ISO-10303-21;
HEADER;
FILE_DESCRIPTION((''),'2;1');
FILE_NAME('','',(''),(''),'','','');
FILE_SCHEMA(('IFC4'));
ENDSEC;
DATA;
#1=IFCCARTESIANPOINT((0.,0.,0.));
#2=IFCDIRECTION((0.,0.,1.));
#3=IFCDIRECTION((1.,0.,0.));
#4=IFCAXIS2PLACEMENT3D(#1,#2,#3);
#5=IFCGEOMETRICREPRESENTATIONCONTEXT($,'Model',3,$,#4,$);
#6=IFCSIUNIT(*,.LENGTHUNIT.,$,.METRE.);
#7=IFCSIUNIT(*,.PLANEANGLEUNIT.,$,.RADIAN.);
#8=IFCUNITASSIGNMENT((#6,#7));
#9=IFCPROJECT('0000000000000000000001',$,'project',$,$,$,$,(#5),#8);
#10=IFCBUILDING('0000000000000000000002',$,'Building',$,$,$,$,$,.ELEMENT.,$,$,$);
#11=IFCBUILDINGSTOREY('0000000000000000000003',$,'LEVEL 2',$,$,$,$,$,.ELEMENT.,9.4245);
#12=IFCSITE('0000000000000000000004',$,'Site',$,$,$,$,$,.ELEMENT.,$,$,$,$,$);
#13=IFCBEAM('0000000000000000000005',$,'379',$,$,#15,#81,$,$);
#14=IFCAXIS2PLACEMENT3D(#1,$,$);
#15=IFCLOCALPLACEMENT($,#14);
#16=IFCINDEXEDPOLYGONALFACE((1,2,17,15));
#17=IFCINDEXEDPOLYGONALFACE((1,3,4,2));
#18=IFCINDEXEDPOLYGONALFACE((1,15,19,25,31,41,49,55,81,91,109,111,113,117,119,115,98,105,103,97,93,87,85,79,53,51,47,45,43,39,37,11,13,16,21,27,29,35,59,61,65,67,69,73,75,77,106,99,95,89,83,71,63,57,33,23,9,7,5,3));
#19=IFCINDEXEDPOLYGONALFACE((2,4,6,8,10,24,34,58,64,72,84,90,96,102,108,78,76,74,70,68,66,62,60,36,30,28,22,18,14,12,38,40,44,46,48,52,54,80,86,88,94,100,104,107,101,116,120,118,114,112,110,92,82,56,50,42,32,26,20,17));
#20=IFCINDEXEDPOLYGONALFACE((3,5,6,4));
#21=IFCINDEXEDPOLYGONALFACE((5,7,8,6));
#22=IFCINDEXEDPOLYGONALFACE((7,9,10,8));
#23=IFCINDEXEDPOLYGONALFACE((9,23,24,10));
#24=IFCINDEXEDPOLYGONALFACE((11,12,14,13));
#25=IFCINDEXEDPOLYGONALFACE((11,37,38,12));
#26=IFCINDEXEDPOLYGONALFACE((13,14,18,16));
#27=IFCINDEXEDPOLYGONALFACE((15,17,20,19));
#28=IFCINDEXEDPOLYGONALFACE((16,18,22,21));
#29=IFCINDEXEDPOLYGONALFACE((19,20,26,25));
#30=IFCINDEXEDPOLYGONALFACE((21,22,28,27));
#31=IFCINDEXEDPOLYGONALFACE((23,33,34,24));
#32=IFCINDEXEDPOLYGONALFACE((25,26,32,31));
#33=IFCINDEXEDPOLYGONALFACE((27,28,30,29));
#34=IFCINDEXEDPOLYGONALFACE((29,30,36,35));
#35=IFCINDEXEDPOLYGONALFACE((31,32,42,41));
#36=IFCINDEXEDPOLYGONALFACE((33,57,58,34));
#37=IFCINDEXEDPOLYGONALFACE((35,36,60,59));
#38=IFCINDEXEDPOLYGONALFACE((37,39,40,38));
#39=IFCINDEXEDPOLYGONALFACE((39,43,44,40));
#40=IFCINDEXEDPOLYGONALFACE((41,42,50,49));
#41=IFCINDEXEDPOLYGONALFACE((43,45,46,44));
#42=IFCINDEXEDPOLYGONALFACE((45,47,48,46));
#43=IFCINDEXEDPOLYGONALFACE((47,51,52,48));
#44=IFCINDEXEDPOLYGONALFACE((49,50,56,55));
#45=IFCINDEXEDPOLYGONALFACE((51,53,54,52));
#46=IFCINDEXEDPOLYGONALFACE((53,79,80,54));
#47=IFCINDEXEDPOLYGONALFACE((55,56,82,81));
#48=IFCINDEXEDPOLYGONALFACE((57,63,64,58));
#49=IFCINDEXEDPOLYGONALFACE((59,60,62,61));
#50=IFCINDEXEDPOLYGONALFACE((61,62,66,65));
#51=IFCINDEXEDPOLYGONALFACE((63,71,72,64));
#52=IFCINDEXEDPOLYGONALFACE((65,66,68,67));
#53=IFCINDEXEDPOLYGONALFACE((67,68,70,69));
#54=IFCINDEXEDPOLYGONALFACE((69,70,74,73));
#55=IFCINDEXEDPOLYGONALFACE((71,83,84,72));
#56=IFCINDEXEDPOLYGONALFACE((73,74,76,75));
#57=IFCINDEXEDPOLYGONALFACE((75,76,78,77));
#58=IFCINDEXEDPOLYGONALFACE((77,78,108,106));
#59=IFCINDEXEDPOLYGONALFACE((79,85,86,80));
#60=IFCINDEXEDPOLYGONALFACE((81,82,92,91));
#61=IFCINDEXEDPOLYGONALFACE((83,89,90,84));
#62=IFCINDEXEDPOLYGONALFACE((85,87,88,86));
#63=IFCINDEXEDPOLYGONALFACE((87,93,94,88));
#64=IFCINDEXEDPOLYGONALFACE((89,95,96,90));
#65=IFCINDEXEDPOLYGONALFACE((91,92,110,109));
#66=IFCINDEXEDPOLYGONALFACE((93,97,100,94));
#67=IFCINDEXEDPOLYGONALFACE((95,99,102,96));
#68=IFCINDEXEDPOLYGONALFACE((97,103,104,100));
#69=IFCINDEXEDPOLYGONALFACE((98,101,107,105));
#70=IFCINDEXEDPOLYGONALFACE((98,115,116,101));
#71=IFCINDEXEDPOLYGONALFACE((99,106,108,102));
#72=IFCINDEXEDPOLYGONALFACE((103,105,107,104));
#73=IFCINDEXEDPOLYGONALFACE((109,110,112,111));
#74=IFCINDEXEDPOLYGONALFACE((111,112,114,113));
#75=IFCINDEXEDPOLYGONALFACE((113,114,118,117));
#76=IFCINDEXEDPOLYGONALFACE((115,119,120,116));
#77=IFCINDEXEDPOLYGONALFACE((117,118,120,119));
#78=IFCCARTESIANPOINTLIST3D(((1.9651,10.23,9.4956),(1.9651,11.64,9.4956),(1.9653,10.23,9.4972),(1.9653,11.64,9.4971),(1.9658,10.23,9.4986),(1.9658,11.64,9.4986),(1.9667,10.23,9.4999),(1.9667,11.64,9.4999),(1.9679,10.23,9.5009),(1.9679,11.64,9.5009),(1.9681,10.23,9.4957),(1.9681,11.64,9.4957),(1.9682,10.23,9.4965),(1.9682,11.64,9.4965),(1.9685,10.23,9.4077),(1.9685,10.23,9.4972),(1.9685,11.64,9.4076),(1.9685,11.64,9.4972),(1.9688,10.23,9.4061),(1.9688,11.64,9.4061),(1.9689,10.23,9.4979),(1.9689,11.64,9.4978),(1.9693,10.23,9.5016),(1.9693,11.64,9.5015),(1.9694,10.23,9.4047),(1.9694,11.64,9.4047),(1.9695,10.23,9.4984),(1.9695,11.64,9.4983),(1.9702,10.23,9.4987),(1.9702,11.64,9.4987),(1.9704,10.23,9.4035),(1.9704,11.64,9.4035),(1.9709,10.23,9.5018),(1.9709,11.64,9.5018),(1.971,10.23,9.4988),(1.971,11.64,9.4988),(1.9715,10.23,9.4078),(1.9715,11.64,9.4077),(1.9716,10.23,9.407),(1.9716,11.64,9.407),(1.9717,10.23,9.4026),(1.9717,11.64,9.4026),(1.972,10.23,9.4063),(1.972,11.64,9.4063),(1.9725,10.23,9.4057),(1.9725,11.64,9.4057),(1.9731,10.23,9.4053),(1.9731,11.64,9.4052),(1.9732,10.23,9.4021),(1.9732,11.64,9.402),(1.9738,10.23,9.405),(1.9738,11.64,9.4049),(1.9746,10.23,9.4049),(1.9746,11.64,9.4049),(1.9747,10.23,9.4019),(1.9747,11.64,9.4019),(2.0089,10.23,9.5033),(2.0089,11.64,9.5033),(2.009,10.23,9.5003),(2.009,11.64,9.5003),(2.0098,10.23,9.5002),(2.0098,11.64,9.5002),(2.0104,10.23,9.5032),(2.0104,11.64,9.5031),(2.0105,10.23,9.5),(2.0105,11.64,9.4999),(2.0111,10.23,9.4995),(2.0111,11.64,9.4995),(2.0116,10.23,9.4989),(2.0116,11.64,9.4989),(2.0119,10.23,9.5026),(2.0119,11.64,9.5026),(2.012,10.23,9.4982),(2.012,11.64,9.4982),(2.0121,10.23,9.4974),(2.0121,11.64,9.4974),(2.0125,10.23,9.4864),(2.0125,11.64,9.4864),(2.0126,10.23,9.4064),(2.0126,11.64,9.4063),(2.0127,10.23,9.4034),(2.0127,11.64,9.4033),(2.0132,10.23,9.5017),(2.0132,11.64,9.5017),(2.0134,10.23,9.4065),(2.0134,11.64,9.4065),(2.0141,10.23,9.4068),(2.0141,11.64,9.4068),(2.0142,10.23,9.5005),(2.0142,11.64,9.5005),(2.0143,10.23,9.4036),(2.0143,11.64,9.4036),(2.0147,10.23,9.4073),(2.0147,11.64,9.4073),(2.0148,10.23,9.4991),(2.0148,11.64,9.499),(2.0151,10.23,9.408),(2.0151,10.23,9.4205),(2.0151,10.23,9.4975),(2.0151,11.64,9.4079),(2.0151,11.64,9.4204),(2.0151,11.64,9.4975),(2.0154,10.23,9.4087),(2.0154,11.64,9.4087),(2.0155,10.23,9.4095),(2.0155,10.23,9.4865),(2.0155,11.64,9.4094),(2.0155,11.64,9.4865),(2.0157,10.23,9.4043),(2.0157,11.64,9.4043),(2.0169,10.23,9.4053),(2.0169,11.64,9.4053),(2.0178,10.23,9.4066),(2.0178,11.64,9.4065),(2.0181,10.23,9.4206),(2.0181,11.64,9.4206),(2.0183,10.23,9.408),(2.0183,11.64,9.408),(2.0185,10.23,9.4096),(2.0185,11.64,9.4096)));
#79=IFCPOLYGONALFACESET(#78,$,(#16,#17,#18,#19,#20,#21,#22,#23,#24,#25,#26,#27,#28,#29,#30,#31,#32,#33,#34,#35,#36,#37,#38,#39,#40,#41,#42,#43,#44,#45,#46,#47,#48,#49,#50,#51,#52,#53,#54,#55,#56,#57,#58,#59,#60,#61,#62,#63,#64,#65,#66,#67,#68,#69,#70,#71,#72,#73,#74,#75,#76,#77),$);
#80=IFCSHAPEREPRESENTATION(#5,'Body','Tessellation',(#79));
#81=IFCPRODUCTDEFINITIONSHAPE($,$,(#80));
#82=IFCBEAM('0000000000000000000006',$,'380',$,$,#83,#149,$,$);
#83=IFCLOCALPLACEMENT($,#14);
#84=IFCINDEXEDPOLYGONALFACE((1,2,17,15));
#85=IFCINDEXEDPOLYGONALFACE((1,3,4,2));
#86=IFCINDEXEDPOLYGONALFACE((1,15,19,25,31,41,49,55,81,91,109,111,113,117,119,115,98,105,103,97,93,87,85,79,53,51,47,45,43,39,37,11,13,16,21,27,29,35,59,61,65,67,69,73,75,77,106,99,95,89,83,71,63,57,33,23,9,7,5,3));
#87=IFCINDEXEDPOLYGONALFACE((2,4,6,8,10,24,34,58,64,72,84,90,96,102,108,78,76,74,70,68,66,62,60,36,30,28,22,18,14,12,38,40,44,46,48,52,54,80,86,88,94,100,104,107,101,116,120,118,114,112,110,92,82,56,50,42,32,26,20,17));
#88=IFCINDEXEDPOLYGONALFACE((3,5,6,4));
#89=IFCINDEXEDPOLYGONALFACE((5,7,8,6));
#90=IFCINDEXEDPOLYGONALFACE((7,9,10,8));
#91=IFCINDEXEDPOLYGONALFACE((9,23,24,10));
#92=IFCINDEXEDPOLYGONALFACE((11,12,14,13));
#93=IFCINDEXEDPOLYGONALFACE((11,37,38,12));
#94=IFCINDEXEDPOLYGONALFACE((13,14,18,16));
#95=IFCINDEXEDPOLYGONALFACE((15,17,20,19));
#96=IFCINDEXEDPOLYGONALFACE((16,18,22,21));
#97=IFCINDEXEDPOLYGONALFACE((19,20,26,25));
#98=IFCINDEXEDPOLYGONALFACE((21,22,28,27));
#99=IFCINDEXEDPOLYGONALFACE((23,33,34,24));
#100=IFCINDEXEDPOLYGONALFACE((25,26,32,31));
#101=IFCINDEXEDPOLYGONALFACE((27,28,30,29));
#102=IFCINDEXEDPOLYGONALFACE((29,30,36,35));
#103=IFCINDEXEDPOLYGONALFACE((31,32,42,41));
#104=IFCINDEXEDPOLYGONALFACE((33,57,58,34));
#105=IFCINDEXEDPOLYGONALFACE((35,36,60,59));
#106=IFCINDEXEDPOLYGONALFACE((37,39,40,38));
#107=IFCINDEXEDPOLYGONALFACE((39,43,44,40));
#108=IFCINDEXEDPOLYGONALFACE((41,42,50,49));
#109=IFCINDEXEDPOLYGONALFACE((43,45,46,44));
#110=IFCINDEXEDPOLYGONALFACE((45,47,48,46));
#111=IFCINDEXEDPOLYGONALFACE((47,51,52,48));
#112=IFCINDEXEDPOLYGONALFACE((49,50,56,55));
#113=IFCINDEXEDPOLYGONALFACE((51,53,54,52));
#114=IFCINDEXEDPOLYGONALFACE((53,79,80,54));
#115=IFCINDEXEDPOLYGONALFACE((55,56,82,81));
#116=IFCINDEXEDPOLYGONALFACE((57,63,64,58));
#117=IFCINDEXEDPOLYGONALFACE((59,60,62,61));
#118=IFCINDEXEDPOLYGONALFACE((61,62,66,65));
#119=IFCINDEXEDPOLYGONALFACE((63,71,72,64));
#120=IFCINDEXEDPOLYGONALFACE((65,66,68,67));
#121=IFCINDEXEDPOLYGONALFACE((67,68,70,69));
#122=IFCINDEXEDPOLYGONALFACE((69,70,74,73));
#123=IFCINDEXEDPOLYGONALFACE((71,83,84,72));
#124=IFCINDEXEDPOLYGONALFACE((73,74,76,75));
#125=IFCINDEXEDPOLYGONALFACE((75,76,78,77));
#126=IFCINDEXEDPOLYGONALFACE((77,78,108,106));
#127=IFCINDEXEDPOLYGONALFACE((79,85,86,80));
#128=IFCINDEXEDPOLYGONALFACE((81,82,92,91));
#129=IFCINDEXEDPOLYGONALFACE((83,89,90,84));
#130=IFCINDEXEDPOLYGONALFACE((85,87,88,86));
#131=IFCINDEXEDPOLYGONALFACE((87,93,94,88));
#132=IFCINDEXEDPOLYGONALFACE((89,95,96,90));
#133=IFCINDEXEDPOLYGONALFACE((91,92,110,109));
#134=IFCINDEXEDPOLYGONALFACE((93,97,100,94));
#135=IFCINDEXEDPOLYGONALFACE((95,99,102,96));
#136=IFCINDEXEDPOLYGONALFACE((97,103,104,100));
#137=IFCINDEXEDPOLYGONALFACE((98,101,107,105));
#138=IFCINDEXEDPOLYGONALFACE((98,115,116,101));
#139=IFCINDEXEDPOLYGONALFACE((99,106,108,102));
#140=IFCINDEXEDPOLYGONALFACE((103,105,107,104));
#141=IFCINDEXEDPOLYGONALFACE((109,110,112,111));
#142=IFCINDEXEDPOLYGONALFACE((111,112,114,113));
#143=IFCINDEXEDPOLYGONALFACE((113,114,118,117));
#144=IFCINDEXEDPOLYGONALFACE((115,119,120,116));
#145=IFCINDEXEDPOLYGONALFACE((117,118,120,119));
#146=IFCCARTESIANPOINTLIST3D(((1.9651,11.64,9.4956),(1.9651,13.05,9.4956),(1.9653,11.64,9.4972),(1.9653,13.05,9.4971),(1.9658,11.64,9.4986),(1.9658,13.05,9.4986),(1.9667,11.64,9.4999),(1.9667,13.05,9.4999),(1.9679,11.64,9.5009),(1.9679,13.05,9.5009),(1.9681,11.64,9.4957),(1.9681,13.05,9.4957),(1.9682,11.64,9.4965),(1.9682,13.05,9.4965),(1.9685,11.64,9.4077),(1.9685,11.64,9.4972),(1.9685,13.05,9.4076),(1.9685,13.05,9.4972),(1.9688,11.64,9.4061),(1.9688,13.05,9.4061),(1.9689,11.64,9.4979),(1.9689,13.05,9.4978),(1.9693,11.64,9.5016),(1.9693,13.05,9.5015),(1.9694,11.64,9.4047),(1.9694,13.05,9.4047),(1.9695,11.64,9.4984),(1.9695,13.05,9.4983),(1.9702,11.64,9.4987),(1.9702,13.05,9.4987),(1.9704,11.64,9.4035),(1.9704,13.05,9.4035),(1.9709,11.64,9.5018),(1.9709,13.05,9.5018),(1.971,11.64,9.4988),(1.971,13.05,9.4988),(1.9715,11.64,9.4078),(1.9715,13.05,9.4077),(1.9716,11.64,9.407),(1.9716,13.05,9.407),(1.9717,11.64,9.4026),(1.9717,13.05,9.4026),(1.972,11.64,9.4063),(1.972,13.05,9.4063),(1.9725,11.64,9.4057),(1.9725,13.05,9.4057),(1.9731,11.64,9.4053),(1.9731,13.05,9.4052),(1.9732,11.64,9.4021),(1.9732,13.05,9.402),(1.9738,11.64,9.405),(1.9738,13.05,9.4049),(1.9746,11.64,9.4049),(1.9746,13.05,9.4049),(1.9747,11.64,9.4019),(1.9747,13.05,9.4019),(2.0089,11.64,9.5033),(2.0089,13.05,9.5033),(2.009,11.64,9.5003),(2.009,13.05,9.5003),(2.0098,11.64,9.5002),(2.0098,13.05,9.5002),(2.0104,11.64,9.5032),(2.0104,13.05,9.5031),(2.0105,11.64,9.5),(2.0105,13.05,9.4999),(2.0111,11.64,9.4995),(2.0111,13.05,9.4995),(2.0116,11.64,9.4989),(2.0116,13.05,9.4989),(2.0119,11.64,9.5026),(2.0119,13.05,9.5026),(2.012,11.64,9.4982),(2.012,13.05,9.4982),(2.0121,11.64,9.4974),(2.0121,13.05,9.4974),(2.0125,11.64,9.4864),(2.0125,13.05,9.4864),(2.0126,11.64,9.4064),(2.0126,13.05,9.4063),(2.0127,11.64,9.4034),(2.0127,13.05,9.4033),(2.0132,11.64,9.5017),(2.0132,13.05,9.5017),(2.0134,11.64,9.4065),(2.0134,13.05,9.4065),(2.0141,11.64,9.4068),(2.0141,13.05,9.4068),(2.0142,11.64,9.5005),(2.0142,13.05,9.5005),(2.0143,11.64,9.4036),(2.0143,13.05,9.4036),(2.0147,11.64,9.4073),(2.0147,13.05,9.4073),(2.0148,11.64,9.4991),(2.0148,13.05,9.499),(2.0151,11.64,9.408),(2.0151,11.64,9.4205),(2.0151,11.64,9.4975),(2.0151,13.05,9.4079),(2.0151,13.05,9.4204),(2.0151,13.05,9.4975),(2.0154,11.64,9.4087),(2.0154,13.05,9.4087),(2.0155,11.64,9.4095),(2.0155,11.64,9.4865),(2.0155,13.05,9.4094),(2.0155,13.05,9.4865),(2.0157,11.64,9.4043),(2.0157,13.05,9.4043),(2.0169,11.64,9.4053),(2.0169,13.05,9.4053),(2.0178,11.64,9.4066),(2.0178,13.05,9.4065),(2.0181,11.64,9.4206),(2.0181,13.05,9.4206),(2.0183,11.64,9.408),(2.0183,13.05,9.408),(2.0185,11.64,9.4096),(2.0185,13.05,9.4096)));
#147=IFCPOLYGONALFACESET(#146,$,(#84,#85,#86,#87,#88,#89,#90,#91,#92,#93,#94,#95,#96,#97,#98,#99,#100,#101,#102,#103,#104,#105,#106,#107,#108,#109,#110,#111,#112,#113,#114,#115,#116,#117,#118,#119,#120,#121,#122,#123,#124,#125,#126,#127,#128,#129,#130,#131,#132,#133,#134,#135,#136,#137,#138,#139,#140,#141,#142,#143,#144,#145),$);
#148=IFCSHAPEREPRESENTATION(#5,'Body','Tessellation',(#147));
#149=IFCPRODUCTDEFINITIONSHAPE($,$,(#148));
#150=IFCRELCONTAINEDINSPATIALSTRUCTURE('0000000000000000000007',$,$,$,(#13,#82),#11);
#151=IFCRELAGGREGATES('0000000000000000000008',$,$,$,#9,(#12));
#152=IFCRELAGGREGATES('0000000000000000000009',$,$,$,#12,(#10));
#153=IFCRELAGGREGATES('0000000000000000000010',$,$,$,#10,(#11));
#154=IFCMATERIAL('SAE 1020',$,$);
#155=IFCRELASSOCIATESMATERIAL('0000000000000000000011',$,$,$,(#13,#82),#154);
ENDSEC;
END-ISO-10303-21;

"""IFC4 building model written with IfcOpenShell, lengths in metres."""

from ifc_helpers import new_model, si_unit, frame, origin_with_axes, origin_2d_with_axis, place, context, project, spatial, c_section, extrude, material, material_profile, profile_set, profile_usage, element, save


model = new_model("IFC4")

# Units and contexts
model_context = context("Model", 3, world=origin_with_axes())
ifc_project = project(units=[si_unit("LENGTHUNIT", "METRE"), si_unit("PLANEANGLEUNIT", "RADIAN")], contexts=[model_context])

# Site, building, storey
site = spatial("IfcSite", under=ifc_project, Name="Site", CompositionType="ELEMENT")
building = spatial("IfcBuilding", under=site, Name="Building", CompositionType="ELEMENT")
storey = spatial("IfcBuildingStorey", under=building, Name="LEVEL 2", CompositionType="ELEMENT", Elevation=9.4245)

# Beams
ifc_material = material(Name="SAE 1020")
ifc_material_profile_1 = material_profile(ifc_material, c_section(Depth=0.1, Width=0.05, WallThickness=0.003, Girth=0.017, InternalFilletRadius=0.003, at=origin_2d_with_axis()))
ifc_profile_set_1 = profile_set([ifc_material_profile_1])
ifc_profile_usage_1 = profile_usage(ifc_profile_set_1, cardinal=10)
beam_1_placement = place(None, frame((1.9918, 10.23, 9.4526), z_axis=(0.0, 1.0, -0.00003), x_axis=(0.999256, 0.000001, 0.038562)))
element("IfcBeam", 1, at=beam_1_placement, inside=storey, material=ifc_profile_usage_1, Name="379", context=model_context, shape_type="SweptSolid", body=[
    extrude(c_section(Depth=0.1, Width=0.05, WallThickness=0.003, Girth=0.017, InternalFilletRadius=0.003, at=origin_2d_with_axis()), origin_with_axes(), (0.0, 0.0, 1.0), 1.41),
])
ifc_material_profile_2 = material_profile(ifc_material, c_section(Depth=0.1, Width=0.05, WallThickness=0.003, Girth=0.017, InternalFilletRadius=0.003, at=origin_2d_with_axis()))
ifc_profile_set_2 = profile_set([ifc_material_profile_2])
ifc_profile_usage_2 = profile_usage(ifc_profile_set_2, cardinal=10)
beam_2_placement = place(None, frame((1.9918, 11.64, 9.4526), z_axis=(0.0, 1.0, -0.00003), x_axis=(0.999256, 0.000001, 0.038562)))
element("IfcBeam", 2, at=beam_2_placement, inside=storey, material=ifc_profile_usage_2, Name="380", context=model_context, shape_type="SweptSolid", body=[
    extrude(c_section(Depth=0.1, Width=0.05, WallThickness=0.003, Girth=0.017, InternalFilletRadius=0.003, at=origin_2d_with_axis()), origin_with_axes(), (0.0, 0.0, 1.0), 1.41),
])

save(model, "model.ifc")
